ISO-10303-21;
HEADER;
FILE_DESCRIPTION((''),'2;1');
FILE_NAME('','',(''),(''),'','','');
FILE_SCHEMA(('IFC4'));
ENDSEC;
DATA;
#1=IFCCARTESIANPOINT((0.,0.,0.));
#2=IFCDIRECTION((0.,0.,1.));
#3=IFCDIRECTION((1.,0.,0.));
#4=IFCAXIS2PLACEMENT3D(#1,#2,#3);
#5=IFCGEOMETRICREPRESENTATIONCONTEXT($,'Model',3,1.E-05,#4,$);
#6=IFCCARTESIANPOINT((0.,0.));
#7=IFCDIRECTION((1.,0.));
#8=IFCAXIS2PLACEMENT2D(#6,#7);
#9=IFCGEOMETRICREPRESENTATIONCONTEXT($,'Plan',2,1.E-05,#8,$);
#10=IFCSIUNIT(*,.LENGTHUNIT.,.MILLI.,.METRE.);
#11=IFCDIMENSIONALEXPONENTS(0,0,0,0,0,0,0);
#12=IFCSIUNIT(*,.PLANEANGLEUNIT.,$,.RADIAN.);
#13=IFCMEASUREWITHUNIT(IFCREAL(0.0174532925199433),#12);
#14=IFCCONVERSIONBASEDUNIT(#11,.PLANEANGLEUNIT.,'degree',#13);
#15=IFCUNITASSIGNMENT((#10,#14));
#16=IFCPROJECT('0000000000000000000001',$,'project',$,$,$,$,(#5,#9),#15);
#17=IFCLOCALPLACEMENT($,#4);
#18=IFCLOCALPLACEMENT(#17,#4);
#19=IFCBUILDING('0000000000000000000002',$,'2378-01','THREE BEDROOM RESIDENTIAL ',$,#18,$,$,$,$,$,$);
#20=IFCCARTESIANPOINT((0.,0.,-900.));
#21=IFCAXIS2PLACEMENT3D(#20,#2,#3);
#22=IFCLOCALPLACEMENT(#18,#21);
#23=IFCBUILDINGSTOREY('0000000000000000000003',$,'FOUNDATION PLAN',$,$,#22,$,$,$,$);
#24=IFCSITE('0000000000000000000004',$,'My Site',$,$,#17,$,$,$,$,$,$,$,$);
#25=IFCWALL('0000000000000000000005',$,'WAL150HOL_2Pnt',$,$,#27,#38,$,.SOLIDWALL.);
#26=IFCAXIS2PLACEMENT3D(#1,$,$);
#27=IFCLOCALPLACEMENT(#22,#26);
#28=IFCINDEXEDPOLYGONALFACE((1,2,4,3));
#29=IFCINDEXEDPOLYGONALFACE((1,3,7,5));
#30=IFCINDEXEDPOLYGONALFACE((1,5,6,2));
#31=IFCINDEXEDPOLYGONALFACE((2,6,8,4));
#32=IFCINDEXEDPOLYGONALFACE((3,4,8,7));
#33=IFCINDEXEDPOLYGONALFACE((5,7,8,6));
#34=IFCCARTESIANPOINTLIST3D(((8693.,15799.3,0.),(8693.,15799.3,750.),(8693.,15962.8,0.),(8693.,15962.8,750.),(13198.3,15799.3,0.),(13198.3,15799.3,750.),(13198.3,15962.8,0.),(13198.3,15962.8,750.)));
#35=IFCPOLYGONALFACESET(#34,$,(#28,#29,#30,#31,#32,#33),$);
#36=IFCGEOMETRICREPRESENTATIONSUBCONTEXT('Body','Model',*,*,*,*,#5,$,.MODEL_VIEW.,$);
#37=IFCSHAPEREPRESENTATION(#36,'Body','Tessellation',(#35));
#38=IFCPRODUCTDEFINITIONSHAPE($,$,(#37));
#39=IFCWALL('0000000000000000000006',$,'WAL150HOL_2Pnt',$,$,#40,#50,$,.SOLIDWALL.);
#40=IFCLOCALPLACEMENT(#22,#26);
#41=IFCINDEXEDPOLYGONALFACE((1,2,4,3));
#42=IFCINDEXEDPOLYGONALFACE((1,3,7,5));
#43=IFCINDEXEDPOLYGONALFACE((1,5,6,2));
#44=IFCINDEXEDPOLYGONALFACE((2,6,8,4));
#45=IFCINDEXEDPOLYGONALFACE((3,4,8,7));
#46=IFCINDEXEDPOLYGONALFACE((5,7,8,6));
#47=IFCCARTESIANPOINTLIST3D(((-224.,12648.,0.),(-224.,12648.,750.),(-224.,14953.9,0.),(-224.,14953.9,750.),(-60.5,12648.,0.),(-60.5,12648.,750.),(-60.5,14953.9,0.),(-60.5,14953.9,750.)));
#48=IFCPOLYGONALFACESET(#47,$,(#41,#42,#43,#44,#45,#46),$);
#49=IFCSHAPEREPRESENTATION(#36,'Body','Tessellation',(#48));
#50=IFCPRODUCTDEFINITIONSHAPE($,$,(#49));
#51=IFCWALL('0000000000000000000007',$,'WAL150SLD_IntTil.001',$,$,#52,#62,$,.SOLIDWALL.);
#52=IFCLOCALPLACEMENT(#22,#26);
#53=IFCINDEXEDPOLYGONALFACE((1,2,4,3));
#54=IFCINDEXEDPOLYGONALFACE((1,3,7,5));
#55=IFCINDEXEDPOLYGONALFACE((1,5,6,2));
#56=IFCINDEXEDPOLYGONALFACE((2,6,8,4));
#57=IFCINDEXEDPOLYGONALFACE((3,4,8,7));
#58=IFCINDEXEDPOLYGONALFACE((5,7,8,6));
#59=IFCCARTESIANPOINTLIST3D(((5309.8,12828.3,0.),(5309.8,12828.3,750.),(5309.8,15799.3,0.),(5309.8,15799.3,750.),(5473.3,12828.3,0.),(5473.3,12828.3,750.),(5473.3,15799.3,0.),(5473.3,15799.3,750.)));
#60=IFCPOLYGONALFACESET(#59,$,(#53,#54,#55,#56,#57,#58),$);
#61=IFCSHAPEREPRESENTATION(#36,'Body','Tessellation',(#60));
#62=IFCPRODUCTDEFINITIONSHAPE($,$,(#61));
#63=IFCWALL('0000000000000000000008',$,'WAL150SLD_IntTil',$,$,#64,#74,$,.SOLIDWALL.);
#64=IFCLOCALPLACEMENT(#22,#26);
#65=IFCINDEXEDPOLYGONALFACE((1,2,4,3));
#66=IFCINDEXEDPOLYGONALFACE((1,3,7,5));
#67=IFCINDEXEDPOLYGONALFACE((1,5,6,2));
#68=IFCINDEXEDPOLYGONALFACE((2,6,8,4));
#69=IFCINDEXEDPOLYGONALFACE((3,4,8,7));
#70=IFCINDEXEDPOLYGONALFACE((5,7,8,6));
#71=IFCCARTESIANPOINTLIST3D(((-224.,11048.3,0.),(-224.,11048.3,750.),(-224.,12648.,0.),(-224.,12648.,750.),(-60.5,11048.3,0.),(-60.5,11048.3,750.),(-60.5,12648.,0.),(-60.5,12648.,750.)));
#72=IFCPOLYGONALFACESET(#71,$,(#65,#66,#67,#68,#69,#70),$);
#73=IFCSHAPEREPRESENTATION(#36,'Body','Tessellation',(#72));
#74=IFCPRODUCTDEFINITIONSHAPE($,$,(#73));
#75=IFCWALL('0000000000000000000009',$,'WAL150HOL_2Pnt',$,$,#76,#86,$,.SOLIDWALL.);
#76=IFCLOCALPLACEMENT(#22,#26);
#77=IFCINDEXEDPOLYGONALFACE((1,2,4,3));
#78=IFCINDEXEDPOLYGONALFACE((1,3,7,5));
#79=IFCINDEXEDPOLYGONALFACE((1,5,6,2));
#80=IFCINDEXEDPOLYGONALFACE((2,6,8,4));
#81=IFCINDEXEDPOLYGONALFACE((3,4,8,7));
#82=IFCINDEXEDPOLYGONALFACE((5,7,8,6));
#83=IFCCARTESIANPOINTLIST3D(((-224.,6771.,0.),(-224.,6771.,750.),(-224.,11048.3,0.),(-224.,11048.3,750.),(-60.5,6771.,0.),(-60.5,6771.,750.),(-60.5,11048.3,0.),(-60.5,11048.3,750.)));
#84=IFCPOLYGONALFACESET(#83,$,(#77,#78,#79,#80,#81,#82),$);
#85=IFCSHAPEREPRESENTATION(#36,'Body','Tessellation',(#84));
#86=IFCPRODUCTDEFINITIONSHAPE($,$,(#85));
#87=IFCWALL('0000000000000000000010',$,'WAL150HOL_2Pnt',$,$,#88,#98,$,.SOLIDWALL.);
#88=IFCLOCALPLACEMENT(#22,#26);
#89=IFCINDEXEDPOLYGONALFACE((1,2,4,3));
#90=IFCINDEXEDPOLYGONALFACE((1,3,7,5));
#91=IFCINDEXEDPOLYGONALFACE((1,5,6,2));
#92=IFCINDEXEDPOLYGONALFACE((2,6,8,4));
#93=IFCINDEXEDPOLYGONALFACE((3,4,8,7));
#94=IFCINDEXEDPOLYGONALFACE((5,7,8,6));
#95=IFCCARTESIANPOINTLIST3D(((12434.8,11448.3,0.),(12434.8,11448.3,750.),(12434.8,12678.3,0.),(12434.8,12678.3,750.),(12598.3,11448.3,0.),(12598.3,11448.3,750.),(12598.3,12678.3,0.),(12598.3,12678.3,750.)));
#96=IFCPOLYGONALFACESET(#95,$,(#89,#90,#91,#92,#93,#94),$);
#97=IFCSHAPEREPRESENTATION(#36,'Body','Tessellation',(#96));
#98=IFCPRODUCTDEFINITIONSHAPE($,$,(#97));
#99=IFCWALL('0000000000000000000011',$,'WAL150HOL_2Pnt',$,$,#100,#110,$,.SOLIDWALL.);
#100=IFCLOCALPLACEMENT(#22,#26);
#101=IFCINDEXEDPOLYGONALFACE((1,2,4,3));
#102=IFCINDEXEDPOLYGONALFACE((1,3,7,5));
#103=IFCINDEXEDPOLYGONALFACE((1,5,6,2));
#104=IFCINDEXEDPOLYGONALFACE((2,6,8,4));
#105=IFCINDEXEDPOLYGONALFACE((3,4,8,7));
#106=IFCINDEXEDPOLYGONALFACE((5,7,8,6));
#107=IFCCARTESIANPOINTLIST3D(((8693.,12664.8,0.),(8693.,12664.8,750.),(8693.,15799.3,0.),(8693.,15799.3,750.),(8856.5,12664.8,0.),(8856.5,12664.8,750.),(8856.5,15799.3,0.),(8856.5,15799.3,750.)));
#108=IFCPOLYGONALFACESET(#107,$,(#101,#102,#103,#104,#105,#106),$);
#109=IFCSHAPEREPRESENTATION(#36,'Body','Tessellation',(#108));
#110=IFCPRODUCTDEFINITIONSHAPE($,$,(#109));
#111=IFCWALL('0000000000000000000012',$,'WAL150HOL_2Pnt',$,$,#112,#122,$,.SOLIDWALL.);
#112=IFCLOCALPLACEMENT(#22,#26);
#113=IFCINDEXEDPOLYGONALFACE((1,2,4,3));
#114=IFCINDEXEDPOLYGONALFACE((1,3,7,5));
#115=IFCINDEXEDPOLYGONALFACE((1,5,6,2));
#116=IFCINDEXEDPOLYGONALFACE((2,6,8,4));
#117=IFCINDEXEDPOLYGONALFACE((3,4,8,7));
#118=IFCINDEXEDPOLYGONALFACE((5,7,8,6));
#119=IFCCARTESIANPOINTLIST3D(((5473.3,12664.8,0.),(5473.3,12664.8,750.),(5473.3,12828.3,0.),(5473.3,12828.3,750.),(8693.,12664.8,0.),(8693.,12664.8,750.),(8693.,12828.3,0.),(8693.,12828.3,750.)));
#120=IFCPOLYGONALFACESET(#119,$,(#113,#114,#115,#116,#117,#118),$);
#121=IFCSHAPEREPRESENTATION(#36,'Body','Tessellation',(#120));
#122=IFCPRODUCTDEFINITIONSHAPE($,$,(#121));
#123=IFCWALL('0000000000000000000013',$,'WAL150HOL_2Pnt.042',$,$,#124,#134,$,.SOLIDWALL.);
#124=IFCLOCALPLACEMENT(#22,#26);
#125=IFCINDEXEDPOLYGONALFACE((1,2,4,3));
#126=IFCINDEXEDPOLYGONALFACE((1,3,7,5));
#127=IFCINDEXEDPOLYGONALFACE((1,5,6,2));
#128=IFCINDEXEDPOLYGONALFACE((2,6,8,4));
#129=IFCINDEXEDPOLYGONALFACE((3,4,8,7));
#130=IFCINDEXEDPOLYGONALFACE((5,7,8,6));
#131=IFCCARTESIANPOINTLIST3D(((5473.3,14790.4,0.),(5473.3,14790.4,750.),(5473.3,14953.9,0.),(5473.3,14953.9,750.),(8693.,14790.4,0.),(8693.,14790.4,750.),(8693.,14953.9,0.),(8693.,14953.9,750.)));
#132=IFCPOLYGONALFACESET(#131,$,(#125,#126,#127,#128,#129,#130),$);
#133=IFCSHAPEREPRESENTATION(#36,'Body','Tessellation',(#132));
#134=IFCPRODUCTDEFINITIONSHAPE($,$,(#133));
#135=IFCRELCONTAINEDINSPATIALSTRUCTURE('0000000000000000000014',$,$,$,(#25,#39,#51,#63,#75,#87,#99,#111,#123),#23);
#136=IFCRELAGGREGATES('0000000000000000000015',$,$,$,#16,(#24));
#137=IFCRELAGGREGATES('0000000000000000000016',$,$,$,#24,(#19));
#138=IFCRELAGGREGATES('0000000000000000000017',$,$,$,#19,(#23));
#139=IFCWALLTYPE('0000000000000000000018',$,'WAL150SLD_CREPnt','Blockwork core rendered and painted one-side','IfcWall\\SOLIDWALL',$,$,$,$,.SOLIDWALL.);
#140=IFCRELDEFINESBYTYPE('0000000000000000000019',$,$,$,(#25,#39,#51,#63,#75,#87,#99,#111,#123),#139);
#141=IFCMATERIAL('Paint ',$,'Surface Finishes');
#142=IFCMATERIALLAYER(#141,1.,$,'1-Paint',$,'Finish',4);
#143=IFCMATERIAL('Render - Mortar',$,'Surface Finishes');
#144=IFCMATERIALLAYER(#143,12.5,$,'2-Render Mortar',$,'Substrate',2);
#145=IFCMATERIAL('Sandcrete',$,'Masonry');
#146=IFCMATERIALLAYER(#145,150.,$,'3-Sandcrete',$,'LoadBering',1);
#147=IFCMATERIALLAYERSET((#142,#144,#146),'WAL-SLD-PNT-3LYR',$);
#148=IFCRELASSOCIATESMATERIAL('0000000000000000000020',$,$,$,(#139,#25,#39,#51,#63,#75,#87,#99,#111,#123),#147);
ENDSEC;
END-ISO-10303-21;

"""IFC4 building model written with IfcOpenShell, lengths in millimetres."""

from ifc_helpers import new_model, entity, si_unit, converted_unit, frame, origin_with_axes, origin_2d_with_axis, place, context, subcontext, project, spatial, indexed_curve, outline, extrude, material, layer, layer_set, layer_usage, type_object, element, save


model = new_model("IFC4")

# Units and contexts
model_context = context("Model", 3, precision=1e-05, world=origin_with_axes())
plan_context = context("Plan", 2, precision=1e-05, world=origin_2d_with_axis())
body_context = subcontext(model_context, "Body", "Model", "MODEL_VIEW")
ifc_project = project(units=[si_unit("LENGTHUNIT", "METRE", prefix="MILLI"), converted_unit("PLANEANGLEUNIT", "degree", entity("IfcReal", 0.0174532925199433), si_unit("PLANEANGLEUNIT", "RADIAN"), dimensions=[0, 0, 0, 0, 0, 0, 0])], contexts=[model_context, plan_context])

# Site, building, storey
site_placement = place(None, origin_with_axes())
site = spatial("IfcSite", under=ifc_project, at=site_placement, Name="My Site")
building_placement = place(site_placement, origin_with_axes())
building = spatial("IfcBuilding", under=site, at=building_placement, Name="2378-01", Description="THREE BEDROOM RESIDENTIAL ")
storey_placement = place(building_placement, frame((0.0, 0.0, -900.0), z_axis=(0.0, 0.0, 1.0), x_axis=(1.0, 0.0, 0.0)))
storey = spatial("IfcBuildingStorey", under=building, at=storey_placement, Name="FOUNDATION PLAN")

# Walls
ifc_material_1 = material(Name="Sandcrete", Category="Masonry")
ifc_material_2 = material(Name="Paint ", Category="Surface Finishes")
ifc_layer_1 = layer(ifc_material_2, 1.0, Name="1-Paint", Category="Finish", Priority=4)
ifc_material_3 = material(Name="Render - Mortar", Category="Surface Finishes")
ifc_layer_2 = layer(ifc_material_3, 12.5, Name="2-Render Mortar", Category="Substrate", Priority=2)
ifc_layer_3 = layer(ifc_material_1, 150.0, Name="3-Sandcrete", Category="LoadBering", Priority=1)
ifc_layer_set_1 = layer_set([ifc_layer_1, ifc_layer_2, ifc_layer_3], Name="WAL-SLD-PNT-3LYR")
wall_type_1 = type_object("IfcWallType", Name="WAL150SLD_CREPnt", Description="Blockwork core rendered and painted one-side", ApplicableOccurrence="IfcWall\\SOLIDWALL", PredefinedType="SOLIDWALL", material=ifc_layer_set_1)
ifc_layer_usage_1 = layer_usage(ifc_layer_set_1, "AXIS2", "POSITIVE", 0.0)
wall_1_placement = place(storey_placement, frame((13198.3, 15962.8, 0.0), z_axis=(0.0, 0.0, 1.0), x_axis=(-1.0, 0.000001, 0.0)))
element("IfcWall", 1, at=wall_1_placement, inside=storey, type_object=wall_type_1, material=ifc_layer_usage_1, Name="WAL150HOL_2Pnt", PredefinedType="SOLIDWALL", context=body_context, shape_type="SweptSolid", body=[
    extrude(outline(indexed_curve([(0.0, 0.0), (0.0, 163.5), (4505.3, 163.5), (4505.3, 0.0), (0.0, 0.0)], self_intersect=False)), origin_with_axes(), (0.0, 0.0, 1.0), 750.0),
])
ifc_layer_usage_2 = layer_usage(ifc_layer_set_1, "AXIS2", "POSITIVE", 0.0)
wall_2_placement = place(storey_placement, frame((-224.0, 14953.9, 0.0), z_axis=(0.0, 0.0, 1.0), x_axis=(0.0, -1.0, 0.0)))
element("IfcWall", 2, at=wall_2_placement, inside=storey, type_object=wall_type_1, material=ifc_layer_usage_2, Name="WAL150HOL_2Pnt", PredefinedType="SOLIDWALL", context=body_context, shape_type="SweptSolid", body=[
    extrude(outline(indexed_curve([(0.0, 0.0), (0.0, 163.5), (2305.9, 163.5), (2305.9, 0.0), (0.0, 0.0)], self_intersect=False)), origin_with_axes(), (0.0, 0.0, 1.0), 750.0),
])
ifc_layer_usage_3 = layer_usage(ifc_layer_set_1, "AXIS2", "POSITIVE", 0.0)
wall_3_placement = place(storey_placement, frame((5473.3, 12828.3, 0.0), z_axis=(0.0, 0.0, 1.0), x_axis=(0.000001, 1.0, 0.0)))
element("IfcWall", 3, at=wall_3_placement, inside=storey, type_object=wall_type_1, material=ifc_layer_usage_3, Name="WAL150SLD_IntTil.001", PredefinedType="SOLIDWALL", context=body_context, shape_type="SweptSolid", body=[
    extrude(outline(indexed_curve([(0.0, 0.0), (0.0, 163.5), (2971.0, 163.5), (2971.0, 0.0), (0.0, 0.0)], self_intersect=False)), origin_with_axes(), (0.0, 0.0, 1.0), 750.0),
])
ifc_layer_usage_4 = layer_usage(ifc_layer_set_1, "AXIS2", "POSITIVE", 0.0)
wall_4_placement = place(storey_placement, frame((-224.0, 12648.0, 0.0), z_axis=(0.0, 0.0, 1.0), x_axis=(0.0, -1.0, 0.0)))
element("IfcWall", 4, at=wall_4_placement, inside=storey, type_object=wall_type_1, material=ifc_layer_usage_4, Name="WAL150SLD_IntTil", PredefinedType="SOLIDWALL", context=body_context, shape_type="SweptSolid", body=[
    extrude(outline(indexed_curve([(0.0, 0.0), (0.0, 163.5), (1599.7, 163.5), (1599.7, 0.0), (0.0, 0.0)], self_intersect=False)), origin_with_axes(), (0.0, 0.0, 1.0), 750.0),
])
ifc_layer_usage_5 = layer_usage(ifc_layer_set_1, "AXIS2", "POSITIVE", 0.0)
wall_5_placement = place(storey_placement, frame((-224.0, 11048.3, 0.0), z_axis=(0.0, 0.0, 1.0), x_axis=(0.0, -1.0, 0.0)))
element("IfcWall", 5, at=wall_5_placement, inside=storey, type_object=wall_type_1, material=ifc_layer_usage_5, Name="WAL150HOL_2Pnt", PredefinedType="SOLIDWALL", context=body_context, shape_type="SweptSolid", body=[
    extrude(outline(indexed_curve([(0.0, 0.0), (0.0, 163.5), (4277.3, 163.5), (4277.3, 0.0), (0.0, 0.0)], self_intersect=False)), origin_with_axes(), (0.0, 0.0, 1.0), 750.0),
])
ifc_layer_usage_6 = layer_usage(ifc_layer_set_1, "AXIS2", "POSITIVE", 0.0)
wall_6_placement = place(storey_placement, frame((12598.3, 11448.3, 0.0), z_axis=(0.0, 0.0, 1.0), x_axis=(0.000002, 1.0, 0.0)))
element("IfcWall", 6, at=wall_6_placement, inside=storey, type_object=wall_type_1, material=ifc_layer_usage_6, Name="WAL150HOL_2Pnt", PredefinedType="SOLIDWALL", context=body_context, shape_type="SweptSolid", body=[
    extrude(outline(indexed_curve([(0.0, 0.0), (0.0, 163.5), (1230.0, 163.5), (1230.0, 0.0), (0.0, 0.0)], self_intersect=False)), origin_with_axes(), (0.0, 0.0, 1.0), 750.0),
])
ifc_layer_usage_7 = layer_usage(ifc_layer_set_1, "AXIS2", "POSITIVE", 0.0)
wall_7_placement = place(storey_placement, frame((8693.0, 15799.3, 0.0), z_axis=(0.0, 0.0, 1.0), x_axis=(-0.000001, -1.0, 0.0)))
element("IfcWall", 7, at=wall_7_placement, inside=storey, type_object=wall_type_1, material=ifc_layer_usage_7, Name="WAL150HOL_2Pnt", PredefinedType="SOLIDWALL", context=body_context, shape_type="SweptSolid", body=[
    extrude(outline(indexed_curve([(0.0, 0.0), (0.0, 163.5), (3134.5, 163.5), (3134.5, 0.0), (0.0, 0.0)], self_intersect=False)), origin_with_axes(), (0.0, 0.0, 1.0), 750.0),
])
ifc_layer_usage_8 = layer_usage(ifc_layer_set_1, "AXIS2", "POSITIVE", 0.0)
wall_8_placement = place(storey_placement, frame((8693.0, 12828.3, 0.0), z_axis=(0.0, 0.0, 1.0), x_axis=(-1.0, 0.000001, 0.0)))
element("IfcWall", 8, at=wall_8_placement, inside=storey, type_object=wall_type_1, material=ifc_layer_usage_8, Name="WAL150HOL_2Pnt", PredefinedType="SOLIDWALL", context=body_context, shape_type="SweptSolid", body=[
    extrude(outline(indexed_curve([(0.0, 0.0), (0.0, 163.5), (3219.7, 163.5), (3219.7, 0.0), (0.0, 0.0)], self_intersect=False)), origin_with_axes(), (0.0, 0.0, 1.0), 750.0),
])
ifc_layer_usage_9 = layer_usage(ifc_layer_set_1, "AXIS2", "POSITIVE", 0.0)
wall_9_placement = place(storey_placement, frame((8693.0, 14953.9, 0.0), z_axis=(0.0, 0.0, 1.0), x_axis=(-1.0, 0.0, 0.0)))
element("IfcWall", 9, at=wall_9_placement, inside=storey, type_object=wall_type_1, material=ifc_layer_usage_9, Name="WAL150HOL_2Pnt.042", PredefinedType="SOLIDWALL", context=body_context, shape_type="SweptSolid", body=[
    extrude(outline(indexed_curve([(0.0, 0.0), (0.0, 163.5), (3219.7, 163.5), (3219.7, 0.0), (0.0, 0.0)], self_intersect=False)), origin_with_axes(), (0.0, 0.0, 1.0), 750.0),
])

save(model, "model.ifc")
